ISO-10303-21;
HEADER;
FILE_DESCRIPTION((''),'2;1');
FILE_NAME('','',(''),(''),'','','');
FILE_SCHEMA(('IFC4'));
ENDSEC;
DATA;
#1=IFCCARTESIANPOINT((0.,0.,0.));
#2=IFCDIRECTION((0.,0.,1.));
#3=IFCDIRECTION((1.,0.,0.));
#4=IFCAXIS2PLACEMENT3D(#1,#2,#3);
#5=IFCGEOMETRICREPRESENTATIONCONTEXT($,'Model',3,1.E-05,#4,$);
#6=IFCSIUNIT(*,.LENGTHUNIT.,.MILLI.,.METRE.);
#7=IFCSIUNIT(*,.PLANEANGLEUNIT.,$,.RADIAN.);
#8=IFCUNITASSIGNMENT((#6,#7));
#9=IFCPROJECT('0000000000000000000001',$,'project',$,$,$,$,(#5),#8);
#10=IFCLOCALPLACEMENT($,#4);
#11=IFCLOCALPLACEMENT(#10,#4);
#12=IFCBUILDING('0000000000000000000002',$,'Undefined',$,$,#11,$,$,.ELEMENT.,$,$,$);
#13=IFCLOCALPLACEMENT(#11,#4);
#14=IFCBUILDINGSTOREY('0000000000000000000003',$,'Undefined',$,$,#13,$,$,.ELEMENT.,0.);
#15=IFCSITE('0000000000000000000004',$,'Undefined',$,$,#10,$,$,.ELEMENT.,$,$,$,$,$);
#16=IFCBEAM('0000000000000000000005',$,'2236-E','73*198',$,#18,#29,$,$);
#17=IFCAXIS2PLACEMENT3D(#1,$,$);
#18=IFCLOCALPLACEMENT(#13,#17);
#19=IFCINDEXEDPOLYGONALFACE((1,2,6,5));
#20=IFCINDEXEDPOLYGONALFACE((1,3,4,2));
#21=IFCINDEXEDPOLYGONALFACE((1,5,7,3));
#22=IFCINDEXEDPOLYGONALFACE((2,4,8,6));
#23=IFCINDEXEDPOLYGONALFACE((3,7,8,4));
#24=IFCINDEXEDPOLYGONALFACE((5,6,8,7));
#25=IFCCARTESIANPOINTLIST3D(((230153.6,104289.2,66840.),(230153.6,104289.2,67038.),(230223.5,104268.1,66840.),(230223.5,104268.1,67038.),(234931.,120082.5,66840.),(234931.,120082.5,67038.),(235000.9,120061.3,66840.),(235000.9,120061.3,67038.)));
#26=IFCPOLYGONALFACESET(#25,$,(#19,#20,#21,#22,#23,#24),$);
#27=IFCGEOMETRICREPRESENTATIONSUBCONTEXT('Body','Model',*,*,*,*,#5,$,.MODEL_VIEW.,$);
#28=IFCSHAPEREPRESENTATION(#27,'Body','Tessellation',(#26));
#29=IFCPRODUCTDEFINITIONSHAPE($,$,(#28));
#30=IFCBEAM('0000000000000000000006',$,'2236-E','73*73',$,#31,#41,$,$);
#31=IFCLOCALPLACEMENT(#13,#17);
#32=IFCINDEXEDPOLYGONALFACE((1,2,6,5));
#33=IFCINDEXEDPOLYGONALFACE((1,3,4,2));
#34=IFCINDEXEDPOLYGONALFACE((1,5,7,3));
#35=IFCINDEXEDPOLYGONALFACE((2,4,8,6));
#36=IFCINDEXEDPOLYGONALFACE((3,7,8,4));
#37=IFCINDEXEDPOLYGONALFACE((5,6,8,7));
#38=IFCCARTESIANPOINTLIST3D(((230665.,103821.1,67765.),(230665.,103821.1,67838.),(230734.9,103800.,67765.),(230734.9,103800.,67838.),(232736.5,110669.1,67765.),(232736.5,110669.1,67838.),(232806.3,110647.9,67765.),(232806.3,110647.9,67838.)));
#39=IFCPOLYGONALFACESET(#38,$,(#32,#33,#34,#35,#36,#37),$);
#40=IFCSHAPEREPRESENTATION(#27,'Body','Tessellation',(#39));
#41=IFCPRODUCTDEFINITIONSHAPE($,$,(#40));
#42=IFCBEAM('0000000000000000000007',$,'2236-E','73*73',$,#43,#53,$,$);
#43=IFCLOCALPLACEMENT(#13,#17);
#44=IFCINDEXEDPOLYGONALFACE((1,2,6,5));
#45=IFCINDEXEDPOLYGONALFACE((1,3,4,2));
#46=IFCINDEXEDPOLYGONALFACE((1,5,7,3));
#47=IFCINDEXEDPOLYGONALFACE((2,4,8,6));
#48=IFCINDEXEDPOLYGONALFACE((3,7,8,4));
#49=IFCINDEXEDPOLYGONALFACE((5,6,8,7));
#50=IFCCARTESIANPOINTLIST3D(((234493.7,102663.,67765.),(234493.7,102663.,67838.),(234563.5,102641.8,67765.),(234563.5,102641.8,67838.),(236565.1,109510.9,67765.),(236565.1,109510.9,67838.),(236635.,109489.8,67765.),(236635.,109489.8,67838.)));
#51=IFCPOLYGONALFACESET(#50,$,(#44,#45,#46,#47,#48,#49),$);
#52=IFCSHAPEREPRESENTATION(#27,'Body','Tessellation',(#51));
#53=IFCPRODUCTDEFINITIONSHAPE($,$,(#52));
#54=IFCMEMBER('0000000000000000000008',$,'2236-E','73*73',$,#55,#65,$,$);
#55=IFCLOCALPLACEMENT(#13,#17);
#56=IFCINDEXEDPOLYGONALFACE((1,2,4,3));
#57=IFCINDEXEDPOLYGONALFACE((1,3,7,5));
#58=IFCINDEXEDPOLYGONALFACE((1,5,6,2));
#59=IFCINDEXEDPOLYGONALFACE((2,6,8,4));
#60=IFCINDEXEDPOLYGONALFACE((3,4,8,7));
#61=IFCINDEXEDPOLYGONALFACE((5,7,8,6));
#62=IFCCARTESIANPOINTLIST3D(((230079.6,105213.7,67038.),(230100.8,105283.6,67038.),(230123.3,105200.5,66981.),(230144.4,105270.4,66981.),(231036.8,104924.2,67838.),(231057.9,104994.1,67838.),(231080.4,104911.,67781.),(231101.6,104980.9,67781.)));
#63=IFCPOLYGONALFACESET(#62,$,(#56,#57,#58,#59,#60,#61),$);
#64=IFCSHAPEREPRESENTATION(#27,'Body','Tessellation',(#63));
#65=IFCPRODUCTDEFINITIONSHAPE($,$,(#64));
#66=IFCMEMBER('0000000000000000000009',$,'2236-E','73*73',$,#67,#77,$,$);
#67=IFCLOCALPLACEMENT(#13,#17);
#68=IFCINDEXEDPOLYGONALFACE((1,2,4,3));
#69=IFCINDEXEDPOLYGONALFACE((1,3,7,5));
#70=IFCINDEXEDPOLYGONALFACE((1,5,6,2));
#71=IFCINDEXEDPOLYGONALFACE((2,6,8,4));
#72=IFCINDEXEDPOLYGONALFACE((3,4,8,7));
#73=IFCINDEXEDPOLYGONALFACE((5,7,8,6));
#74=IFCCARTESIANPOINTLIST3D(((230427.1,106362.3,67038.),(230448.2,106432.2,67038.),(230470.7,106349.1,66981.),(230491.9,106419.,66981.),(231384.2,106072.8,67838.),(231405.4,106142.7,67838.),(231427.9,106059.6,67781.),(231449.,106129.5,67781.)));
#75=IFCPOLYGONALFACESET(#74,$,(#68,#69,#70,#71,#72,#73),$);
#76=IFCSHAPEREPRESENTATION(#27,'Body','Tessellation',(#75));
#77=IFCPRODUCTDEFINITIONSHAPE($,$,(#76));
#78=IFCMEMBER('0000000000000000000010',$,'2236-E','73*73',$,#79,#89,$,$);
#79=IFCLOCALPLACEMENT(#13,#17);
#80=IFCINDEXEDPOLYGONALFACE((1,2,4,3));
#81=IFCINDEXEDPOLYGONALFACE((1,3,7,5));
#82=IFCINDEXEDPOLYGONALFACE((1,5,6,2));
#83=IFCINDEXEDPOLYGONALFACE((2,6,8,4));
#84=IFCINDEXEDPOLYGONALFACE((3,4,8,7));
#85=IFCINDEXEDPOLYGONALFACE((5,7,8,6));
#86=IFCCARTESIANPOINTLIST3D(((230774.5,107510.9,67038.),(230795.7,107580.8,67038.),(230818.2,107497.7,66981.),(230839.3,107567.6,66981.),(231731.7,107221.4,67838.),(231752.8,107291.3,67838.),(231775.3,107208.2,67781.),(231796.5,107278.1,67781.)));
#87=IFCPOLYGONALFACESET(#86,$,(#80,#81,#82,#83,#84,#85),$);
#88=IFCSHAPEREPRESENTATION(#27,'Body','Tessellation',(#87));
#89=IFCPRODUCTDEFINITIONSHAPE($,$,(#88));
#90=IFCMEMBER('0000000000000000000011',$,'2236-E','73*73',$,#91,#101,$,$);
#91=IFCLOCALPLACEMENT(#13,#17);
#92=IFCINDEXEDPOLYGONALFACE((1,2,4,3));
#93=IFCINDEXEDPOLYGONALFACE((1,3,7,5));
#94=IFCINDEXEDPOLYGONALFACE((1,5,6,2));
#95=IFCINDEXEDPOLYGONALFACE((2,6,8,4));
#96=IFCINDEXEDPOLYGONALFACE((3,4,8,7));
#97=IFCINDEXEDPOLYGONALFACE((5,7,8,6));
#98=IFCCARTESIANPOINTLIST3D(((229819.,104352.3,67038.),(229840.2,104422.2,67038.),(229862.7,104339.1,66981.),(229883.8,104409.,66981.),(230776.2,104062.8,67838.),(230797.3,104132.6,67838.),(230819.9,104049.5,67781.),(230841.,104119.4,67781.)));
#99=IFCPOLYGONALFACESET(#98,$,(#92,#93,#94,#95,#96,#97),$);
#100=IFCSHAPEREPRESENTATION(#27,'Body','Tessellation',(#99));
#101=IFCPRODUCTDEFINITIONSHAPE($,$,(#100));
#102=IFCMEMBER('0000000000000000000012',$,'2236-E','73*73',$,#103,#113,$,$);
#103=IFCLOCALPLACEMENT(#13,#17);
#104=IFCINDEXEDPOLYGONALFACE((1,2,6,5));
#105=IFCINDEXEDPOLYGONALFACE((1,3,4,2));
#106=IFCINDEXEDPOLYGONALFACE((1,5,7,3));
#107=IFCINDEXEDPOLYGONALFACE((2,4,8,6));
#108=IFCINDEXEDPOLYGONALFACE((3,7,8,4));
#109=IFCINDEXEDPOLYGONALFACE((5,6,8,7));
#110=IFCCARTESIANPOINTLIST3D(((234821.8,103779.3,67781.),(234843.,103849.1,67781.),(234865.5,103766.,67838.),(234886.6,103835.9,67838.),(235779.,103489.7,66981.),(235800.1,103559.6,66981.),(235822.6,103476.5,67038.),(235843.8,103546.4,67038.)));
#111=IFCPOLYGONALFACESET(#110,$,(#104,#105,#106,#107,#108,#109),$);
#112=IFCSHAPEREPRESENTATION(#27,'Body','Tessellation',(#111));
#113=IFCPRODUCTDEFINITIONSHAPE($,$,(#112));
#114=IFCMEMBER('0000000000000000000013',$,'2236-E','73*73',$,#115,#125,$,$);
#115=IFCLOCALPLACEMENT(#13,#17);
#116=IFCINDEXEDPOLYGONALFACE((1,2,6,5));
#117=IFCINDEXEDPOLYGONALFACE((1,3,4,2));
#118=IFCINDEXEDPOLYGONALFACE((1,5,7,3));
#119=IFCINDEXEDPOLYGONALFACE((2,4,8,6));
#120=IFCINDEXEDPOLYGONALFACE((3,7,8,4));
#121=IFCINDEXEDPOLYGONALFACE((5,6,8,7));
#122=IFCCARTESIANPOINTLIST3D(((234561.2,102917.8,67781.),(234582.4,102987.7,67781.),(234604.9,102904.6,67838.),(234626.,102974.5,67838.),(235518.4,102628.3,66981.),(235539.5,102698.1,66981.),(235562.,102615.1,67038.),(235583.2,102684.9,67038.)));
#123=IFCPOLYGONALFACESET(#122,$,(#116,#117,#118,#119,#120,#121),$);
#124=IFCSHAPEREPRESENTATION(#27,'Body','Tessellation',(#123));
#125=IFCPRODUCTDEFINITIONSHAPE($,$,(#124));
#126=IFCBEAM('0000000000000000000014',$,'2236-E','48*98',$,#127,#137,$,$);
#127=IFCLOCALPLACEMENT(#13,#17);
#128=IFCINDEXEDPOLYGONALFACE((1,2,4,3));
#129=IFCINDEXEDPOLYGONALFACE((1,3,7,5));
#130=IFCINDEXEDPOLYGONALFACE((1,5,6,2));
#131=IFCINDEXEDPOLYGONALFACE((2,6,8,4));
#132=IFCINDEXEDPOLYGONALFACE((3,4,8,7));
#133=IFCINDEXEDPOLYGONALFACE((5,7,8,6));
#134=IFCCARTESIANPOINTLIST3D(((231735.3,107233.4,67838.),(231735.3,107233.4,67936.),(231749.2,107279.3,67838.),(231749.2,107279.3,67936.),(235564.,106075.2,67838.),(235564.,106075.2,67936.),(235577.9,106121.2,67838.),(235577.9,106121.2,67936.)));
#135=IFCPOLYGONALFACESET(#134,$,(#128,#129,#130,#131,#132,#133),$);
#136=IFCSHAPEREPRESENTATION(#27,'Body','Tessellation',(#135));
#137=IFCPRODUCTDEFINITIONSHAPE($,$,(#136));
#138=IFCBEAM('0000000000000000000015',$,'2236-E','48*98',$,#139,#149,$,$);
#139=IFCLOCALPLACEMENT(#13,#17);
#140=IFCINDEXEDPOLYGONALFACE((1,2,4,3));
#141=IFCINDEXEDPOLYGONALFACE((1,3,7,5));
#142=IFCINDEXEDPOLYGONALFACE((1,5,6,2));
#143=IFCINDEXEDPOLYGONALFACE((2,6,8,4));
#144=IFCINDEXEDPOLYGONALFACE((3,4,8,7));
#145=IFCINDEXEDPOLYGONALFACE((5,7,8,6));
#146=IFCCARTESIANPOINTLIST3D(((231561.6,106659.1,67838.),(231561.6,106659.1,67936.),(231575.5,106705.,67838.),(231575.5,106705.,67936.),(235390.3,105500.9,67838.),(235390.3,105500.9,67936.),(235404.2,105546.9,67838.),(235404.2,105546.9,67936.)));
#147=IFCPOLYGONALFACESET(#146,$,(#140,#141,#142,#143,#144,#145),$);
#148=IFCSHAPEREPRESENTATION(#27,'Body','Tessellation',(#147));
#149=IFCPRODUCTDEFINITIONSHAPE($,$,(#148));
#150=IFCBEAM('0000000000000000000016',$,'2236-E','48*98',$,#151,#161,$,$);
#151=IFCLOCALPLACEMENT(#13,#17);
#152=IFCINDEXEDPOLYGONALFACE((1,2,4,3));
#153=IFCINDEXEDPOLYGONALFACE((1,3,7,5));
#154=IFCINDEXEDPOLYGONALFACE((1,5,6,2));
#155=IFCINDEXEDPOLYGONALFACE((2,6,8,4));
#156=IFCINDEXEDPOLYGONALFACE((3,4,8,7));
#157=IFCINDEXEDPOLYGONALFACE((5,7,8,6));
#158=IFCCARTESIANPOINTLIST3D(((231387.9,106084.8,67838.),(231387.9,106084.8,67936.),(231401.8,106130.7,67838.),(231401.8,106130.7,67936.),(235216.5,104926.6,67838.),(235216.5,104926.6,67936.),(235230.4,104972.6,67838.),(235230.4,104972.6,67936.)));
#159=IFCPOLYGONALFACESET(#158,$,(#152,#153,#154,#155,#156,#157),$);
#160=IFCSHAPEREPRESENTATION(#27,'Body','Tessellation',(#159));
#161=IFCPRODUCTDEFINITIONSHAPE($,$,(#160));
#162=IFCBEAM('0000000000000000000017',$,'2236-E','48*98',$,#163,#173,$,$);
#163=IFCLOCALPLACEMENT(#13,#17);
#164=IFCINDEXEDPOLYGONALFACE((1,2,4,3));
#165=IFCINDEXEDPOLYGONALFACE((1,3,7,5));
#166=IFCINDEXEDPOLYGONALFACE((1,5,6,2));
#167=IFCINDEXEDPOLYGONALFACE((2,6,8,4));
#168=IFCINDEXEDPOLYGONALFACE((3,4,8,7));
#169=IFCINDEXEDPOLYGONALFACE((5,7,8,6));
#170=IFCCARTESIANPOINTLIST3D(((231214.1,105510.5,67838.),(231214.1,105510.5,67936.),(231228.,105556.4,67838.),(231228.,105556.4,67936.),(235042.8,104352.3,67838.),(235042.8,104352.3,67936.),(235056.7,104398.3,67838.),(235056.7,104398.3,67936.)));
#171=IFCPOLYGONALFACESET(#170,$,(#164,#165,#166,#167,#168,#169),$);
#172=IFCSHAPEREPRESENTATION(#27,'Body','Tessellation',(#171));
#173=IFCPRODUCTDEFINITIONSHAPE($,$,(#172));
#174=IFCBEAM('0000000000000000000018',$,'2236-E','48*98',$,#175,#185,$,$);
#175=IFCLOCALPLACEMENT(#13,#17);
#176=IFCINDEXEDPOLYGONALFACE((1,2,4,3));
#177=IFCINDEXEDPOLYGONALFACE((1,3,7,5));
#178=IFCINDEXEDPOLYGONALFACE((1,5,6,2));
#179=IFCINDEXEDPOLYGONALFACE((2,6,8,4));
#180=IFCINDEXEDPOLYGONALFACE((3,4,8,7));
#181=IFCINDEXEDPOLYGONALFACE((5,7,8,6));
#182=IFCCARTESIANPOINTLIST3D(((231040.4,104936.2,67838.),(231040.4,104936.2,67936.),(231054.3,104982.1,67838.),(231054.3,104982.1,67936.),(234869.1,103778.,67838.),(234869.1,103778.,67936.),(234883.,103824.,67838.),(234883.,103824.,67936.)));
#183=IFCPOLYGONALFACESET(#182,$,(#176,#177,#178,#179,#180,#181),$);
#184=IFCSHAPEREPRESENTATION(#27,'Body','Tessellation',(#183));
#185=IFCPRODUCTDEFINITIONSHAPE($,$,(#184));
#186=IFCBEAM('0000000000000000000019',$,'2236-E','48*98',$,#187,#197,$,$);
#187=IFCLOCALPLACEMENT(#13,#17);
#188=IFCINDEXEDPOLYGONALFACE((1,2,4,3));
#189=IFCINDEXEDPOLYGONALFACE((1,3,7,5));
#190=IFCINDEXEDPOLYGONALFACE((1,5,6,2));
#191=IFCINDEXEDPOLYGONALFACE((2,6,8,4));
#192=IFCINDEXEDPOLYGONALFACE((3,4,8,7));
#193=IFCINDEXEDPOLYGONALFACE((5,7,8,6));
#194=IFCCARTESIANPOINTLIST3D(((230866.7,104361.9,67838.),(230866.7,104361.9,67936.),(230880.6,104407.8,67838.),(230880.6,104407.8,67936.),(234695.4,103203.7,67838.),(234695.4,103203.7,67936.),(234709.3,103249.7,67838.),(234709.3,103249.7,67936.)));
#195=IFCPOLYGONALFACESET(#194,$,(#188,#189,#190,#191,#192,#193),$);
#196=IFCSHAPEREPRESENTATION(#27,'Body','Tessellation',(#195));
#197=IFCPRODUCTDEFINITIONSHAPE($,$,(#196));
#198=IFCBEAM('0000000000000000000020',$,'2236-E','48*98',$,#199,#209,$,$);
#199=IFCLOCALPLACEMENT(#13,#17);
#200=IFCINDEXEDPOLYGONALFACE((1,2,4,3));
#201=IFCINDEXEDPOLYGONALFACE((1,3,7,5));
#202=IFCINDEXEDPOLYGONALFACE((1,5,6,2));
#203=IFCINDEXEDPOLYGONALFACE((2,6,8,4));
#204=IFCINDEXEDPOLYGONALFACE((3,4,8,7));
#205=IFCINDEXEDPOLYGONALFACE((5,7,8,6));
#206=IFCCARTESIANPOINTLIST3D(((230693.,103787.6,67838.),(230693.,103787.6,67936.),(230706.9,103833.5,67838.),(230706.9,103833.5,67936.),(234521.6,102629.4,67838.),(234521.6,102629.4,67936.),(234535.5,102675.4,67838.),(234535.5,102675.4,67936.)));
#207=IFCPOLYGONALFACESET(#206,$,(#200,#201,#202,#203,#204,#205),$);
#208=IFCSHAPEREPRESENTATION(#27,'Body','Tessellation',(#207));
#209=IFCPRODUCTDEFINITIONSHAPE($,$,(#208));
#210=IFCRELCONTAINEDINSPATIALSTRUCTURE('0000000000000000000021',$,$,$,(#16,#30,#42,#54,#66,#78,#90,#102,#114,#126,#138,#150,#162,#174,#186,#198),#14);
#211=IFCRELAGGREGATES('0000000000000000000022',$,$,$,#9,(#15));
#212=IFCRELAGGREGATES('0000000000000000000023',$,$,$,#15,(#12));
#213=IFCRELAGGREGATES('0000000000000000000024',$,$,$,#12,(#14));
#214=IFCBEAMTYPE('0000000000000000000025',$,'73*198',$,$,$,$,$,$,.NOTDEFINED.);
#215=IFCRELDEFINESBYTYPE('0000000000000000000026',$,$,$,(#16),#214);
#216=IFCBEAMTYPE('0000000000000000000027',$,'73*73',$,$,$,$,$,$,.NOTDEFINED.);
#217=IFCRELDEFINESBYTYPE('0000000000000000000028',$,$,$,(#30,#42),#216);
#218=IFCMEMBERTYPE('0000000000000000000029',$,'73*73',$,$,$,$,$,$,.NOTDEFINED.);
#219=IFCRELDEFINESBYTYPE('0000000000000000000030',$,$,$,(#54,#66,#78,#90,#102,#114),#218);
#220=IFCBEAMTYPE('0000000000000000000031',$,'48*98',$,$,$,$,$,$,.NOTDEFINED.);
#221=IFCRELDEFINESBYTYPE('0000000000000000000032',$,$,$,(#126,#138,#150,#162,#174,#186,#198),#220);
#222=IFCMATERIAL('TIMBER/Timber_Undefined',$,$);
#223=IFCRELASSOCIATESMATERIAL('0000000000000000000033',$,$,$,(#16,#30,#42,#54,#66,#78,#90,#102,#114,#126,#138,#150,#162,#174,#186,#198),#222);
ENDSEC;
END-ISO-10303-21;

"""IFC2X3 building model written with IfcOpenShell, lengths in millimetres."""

from ifc_helpers import new_model, si_unit, frame, origin_with_axes, origin_2d_with_axis, place, context, subcontext, project, spatial, rectangle, extrude, material, type_object, element, save


model = new_model("IFC2X3")

# Units and contexts
model_context = context("Model", 3, precision=1e-05, world=origin_with_axes())
body_context = subcontext(model_context, "Body", "Model", "MODEL_VIEW")
ifc_project = project(units=[si_unit("LENGTHUNIT", "METRE", prefix="MILLI"), si_unit("PLANEANGLEUNIT", "RADIAN")], contexts=[model_context])

# Site, building, storey
site_placement = place(None, origin_with_axes())
site = spatial("IfcSite", under=ifc_project, at=site_placement, Name="Undefined", CompositionType="ELEMENT")
building_placement = place(site_placement, origin_with_axes())
building = spatial("IfcBuilding", under=site, at=building_placement, Name="Undefined", CompositionType="ELEMENT")
storey_placement = place(building_placement, origin_with_axes())
storey = spatial("IfcBuildingStorey", under=building, at=storey_placement, Name="Undefined", CompositionType="ELEMENT", Elevation=0.0)

# Beams
ifc_material_1 = material(Name="TIMBER/Timber_Undefined")
beam_type_1 = type_object("IfcBeamType", Name="73*198", PredefinedType="NOTDEFINED")
beam_1_placement = place(storey_placement, frame((230188.6, 104278.6, 66939.0), z_axis=(-0.957167, 0.289538, 0.0), x_axis=(0.289538, 0.957166, 0.0)))
element("IfcBeam", 1, at=beam_1_placement, inside=storey, type_object=beam_type_1, material=ifc_material_1, Name="2236-E", Description="73*198", context=body_context, shape_type="SweptSolid", body=[
    extrude(rectangle(XDim=198.0, YDim=73.0, at=origin_2d_with_axis()), frame((16500.0, 0.0, 0.0), z_axis=(-1.0, 0.0, 0.0), x_axis=(0.0, -1.0, 0.0)), (0.0, 0.0, 1.0), 16500.0),
])
beam_type_2 = type_object("IfcBeamType", Name="73*73", PredefinedType="NOTDEFINED")
for number, where, z_axis, x_axis, name in (
    (2, (230699.9, 103810.5, 67801.5), (-0.957167, 0.289538, 0.0), (0.289538, 0.957166, 0.0), "2236-E"),
    (3, (234528.6, 102652.4, 67801.5), (-0.957167, 0.289538, 0.0), (0.289538, 0.957166, 0.0), "2236-E"),
):
    element("IfcBeam", number, at=place(storey_placement, frame(where, z_axis=z_axis, x_axis=x_axis)), inside=storey, type_object=beam_type_2, material=ifc_material_1, Name=name, Description="73*73", context=body_context, shape_type="SweptSolid", body=[
        extrude(rectangle(XDim=73.0, YDim=73.0, at=origin_2d_with_axis()), frame((7154.4, 0.0, 0.0), z_axis=(-1.0, 0.0, 0.0), x_axis=(0.0, -1.0, 0.0)), (0.0, 0.0, 1.0), 7154.4),
    ])

# Members
member_type = type_object("IfcMemberType", Name="73*73", PredefinedType="NOTDEFINED")
for number, where, z_axis, x_axis, name in (
    (4, (231069.2, 104952.5, 67809.5), (0.289538, 0.957166, 0.0), (-0.747421, 0.226091, -0.624695), "2236-E"),
    (5, (231416.6, 106101.1, 67809.5), (0.289538, 0.957166, 0.0), (-0.747421, 0.226091, -0.624695), "2236-E"),
    (6, (231764.1, 107249.7, 67809.5), (0.289538, 0.957166, 0.0), (-0.747421, 0.226091, -0.624695), "2236-E"),
    (7, (230808.6, 104091.1, 67809.5), (0.289538, 0.957166, 0.0), (-0.747421, 0.226091, -0.624695), "2236-E"),
    (8, (234854.2, 103807.6, 67809.5), (0.289538, 0.957166, 0.0), (0.747421, -0.226091, -0.624695), "2236-E"),
    (9, (234593.6, 102946.1, 67809.5), (0.289538, 0.957166, 0.0), (0.747421, -0.226091, -0.624695), "2236-E"),
):
    element("IfcMember", number, at=place(storey_placement, frame(where, z_axis=z_axis, x_axis=x_axis)), inside=storey, type_object=member_type, material=ifc_material_1, Name=name, Description="73*73", context=body_context, shape_type="SweptSolid", body=[
        extrude(rectangle(XDim=73.0, YDim=73.0, at=origin_2d_with_axis()), frame((1280.6, 0.0, 0.0), z_axis=(-1.0, 0.0, 0.0), x_axis=(0.0, -1.0, 0.0)), (0.0, 0.0, 1.0), 1280.6),
    ])

# Beams
beam_type_3 = type_object("IfcBeamType", Name="48*98", PredefinedType="NOTDEFINED")
for number, where, z_axis, x_axis, name in (
    (10, (231742.3, 107256.3, 67887.0), (0.289538, 0.957166, 0.0), (0.957167, -0.289538, 0.0), "2236-E"),
    (11, (231568.5, 106682.0, 67887.0), (0.289538, 0.957166, 0.0), (0.957167, -0.289538, 0.0), "2236-E"),
    (12, (231394.8, 106107.7, 67887.0), (0.289538, 0.957166, 0.0), (0.957167, -0.289538, 0.0), "2236-E"),
    (13, (231221.1, 105533.4, 67887.0), (0.289538, 0.957166, 0.0), (0.957167, -0.289538, 0.0), "2236-E"),
    (14, (231047.4, 104959.1, 67887.0), (0.289538, 0.957166, 0.0), (0.957167, -0.289538, 0.0), "2236-E"),
    (15, (230873.6, 104384.8, 67887.0), (0.289538, 0.957166, 0.0), (0.957167, -0.289538, 0.0), "2236-E"),
    (16, (230699.9, 103810.5, 67887.0), (0.289538, 0.957166, 0.0), (0.957167, -0.289538, 0.0), "2236-E"),
):
    element("IfcBeam", number, at=place(storey_placement, frame(where, z_axis=z_axis, x_axis=x_axis)), inside=storey, type_object=beam_type_3, material=ifc_material_1, Name=name, Description="48*98", context=body_context, shape_type="SweptSolid", body=[
        extrude(rectangle(XDim=98.0, YDim=48.0, at=origin_2d_with_axis()), frame((4000.0, 0.0, 0.0), z_axis=(-1.0, 0.0, 0.0), x_axis=(0.0, -1.0, 0.0)), (0.0, 0.0, 1.0), 4000.0),
    ])

save(model, "model.ifc")
